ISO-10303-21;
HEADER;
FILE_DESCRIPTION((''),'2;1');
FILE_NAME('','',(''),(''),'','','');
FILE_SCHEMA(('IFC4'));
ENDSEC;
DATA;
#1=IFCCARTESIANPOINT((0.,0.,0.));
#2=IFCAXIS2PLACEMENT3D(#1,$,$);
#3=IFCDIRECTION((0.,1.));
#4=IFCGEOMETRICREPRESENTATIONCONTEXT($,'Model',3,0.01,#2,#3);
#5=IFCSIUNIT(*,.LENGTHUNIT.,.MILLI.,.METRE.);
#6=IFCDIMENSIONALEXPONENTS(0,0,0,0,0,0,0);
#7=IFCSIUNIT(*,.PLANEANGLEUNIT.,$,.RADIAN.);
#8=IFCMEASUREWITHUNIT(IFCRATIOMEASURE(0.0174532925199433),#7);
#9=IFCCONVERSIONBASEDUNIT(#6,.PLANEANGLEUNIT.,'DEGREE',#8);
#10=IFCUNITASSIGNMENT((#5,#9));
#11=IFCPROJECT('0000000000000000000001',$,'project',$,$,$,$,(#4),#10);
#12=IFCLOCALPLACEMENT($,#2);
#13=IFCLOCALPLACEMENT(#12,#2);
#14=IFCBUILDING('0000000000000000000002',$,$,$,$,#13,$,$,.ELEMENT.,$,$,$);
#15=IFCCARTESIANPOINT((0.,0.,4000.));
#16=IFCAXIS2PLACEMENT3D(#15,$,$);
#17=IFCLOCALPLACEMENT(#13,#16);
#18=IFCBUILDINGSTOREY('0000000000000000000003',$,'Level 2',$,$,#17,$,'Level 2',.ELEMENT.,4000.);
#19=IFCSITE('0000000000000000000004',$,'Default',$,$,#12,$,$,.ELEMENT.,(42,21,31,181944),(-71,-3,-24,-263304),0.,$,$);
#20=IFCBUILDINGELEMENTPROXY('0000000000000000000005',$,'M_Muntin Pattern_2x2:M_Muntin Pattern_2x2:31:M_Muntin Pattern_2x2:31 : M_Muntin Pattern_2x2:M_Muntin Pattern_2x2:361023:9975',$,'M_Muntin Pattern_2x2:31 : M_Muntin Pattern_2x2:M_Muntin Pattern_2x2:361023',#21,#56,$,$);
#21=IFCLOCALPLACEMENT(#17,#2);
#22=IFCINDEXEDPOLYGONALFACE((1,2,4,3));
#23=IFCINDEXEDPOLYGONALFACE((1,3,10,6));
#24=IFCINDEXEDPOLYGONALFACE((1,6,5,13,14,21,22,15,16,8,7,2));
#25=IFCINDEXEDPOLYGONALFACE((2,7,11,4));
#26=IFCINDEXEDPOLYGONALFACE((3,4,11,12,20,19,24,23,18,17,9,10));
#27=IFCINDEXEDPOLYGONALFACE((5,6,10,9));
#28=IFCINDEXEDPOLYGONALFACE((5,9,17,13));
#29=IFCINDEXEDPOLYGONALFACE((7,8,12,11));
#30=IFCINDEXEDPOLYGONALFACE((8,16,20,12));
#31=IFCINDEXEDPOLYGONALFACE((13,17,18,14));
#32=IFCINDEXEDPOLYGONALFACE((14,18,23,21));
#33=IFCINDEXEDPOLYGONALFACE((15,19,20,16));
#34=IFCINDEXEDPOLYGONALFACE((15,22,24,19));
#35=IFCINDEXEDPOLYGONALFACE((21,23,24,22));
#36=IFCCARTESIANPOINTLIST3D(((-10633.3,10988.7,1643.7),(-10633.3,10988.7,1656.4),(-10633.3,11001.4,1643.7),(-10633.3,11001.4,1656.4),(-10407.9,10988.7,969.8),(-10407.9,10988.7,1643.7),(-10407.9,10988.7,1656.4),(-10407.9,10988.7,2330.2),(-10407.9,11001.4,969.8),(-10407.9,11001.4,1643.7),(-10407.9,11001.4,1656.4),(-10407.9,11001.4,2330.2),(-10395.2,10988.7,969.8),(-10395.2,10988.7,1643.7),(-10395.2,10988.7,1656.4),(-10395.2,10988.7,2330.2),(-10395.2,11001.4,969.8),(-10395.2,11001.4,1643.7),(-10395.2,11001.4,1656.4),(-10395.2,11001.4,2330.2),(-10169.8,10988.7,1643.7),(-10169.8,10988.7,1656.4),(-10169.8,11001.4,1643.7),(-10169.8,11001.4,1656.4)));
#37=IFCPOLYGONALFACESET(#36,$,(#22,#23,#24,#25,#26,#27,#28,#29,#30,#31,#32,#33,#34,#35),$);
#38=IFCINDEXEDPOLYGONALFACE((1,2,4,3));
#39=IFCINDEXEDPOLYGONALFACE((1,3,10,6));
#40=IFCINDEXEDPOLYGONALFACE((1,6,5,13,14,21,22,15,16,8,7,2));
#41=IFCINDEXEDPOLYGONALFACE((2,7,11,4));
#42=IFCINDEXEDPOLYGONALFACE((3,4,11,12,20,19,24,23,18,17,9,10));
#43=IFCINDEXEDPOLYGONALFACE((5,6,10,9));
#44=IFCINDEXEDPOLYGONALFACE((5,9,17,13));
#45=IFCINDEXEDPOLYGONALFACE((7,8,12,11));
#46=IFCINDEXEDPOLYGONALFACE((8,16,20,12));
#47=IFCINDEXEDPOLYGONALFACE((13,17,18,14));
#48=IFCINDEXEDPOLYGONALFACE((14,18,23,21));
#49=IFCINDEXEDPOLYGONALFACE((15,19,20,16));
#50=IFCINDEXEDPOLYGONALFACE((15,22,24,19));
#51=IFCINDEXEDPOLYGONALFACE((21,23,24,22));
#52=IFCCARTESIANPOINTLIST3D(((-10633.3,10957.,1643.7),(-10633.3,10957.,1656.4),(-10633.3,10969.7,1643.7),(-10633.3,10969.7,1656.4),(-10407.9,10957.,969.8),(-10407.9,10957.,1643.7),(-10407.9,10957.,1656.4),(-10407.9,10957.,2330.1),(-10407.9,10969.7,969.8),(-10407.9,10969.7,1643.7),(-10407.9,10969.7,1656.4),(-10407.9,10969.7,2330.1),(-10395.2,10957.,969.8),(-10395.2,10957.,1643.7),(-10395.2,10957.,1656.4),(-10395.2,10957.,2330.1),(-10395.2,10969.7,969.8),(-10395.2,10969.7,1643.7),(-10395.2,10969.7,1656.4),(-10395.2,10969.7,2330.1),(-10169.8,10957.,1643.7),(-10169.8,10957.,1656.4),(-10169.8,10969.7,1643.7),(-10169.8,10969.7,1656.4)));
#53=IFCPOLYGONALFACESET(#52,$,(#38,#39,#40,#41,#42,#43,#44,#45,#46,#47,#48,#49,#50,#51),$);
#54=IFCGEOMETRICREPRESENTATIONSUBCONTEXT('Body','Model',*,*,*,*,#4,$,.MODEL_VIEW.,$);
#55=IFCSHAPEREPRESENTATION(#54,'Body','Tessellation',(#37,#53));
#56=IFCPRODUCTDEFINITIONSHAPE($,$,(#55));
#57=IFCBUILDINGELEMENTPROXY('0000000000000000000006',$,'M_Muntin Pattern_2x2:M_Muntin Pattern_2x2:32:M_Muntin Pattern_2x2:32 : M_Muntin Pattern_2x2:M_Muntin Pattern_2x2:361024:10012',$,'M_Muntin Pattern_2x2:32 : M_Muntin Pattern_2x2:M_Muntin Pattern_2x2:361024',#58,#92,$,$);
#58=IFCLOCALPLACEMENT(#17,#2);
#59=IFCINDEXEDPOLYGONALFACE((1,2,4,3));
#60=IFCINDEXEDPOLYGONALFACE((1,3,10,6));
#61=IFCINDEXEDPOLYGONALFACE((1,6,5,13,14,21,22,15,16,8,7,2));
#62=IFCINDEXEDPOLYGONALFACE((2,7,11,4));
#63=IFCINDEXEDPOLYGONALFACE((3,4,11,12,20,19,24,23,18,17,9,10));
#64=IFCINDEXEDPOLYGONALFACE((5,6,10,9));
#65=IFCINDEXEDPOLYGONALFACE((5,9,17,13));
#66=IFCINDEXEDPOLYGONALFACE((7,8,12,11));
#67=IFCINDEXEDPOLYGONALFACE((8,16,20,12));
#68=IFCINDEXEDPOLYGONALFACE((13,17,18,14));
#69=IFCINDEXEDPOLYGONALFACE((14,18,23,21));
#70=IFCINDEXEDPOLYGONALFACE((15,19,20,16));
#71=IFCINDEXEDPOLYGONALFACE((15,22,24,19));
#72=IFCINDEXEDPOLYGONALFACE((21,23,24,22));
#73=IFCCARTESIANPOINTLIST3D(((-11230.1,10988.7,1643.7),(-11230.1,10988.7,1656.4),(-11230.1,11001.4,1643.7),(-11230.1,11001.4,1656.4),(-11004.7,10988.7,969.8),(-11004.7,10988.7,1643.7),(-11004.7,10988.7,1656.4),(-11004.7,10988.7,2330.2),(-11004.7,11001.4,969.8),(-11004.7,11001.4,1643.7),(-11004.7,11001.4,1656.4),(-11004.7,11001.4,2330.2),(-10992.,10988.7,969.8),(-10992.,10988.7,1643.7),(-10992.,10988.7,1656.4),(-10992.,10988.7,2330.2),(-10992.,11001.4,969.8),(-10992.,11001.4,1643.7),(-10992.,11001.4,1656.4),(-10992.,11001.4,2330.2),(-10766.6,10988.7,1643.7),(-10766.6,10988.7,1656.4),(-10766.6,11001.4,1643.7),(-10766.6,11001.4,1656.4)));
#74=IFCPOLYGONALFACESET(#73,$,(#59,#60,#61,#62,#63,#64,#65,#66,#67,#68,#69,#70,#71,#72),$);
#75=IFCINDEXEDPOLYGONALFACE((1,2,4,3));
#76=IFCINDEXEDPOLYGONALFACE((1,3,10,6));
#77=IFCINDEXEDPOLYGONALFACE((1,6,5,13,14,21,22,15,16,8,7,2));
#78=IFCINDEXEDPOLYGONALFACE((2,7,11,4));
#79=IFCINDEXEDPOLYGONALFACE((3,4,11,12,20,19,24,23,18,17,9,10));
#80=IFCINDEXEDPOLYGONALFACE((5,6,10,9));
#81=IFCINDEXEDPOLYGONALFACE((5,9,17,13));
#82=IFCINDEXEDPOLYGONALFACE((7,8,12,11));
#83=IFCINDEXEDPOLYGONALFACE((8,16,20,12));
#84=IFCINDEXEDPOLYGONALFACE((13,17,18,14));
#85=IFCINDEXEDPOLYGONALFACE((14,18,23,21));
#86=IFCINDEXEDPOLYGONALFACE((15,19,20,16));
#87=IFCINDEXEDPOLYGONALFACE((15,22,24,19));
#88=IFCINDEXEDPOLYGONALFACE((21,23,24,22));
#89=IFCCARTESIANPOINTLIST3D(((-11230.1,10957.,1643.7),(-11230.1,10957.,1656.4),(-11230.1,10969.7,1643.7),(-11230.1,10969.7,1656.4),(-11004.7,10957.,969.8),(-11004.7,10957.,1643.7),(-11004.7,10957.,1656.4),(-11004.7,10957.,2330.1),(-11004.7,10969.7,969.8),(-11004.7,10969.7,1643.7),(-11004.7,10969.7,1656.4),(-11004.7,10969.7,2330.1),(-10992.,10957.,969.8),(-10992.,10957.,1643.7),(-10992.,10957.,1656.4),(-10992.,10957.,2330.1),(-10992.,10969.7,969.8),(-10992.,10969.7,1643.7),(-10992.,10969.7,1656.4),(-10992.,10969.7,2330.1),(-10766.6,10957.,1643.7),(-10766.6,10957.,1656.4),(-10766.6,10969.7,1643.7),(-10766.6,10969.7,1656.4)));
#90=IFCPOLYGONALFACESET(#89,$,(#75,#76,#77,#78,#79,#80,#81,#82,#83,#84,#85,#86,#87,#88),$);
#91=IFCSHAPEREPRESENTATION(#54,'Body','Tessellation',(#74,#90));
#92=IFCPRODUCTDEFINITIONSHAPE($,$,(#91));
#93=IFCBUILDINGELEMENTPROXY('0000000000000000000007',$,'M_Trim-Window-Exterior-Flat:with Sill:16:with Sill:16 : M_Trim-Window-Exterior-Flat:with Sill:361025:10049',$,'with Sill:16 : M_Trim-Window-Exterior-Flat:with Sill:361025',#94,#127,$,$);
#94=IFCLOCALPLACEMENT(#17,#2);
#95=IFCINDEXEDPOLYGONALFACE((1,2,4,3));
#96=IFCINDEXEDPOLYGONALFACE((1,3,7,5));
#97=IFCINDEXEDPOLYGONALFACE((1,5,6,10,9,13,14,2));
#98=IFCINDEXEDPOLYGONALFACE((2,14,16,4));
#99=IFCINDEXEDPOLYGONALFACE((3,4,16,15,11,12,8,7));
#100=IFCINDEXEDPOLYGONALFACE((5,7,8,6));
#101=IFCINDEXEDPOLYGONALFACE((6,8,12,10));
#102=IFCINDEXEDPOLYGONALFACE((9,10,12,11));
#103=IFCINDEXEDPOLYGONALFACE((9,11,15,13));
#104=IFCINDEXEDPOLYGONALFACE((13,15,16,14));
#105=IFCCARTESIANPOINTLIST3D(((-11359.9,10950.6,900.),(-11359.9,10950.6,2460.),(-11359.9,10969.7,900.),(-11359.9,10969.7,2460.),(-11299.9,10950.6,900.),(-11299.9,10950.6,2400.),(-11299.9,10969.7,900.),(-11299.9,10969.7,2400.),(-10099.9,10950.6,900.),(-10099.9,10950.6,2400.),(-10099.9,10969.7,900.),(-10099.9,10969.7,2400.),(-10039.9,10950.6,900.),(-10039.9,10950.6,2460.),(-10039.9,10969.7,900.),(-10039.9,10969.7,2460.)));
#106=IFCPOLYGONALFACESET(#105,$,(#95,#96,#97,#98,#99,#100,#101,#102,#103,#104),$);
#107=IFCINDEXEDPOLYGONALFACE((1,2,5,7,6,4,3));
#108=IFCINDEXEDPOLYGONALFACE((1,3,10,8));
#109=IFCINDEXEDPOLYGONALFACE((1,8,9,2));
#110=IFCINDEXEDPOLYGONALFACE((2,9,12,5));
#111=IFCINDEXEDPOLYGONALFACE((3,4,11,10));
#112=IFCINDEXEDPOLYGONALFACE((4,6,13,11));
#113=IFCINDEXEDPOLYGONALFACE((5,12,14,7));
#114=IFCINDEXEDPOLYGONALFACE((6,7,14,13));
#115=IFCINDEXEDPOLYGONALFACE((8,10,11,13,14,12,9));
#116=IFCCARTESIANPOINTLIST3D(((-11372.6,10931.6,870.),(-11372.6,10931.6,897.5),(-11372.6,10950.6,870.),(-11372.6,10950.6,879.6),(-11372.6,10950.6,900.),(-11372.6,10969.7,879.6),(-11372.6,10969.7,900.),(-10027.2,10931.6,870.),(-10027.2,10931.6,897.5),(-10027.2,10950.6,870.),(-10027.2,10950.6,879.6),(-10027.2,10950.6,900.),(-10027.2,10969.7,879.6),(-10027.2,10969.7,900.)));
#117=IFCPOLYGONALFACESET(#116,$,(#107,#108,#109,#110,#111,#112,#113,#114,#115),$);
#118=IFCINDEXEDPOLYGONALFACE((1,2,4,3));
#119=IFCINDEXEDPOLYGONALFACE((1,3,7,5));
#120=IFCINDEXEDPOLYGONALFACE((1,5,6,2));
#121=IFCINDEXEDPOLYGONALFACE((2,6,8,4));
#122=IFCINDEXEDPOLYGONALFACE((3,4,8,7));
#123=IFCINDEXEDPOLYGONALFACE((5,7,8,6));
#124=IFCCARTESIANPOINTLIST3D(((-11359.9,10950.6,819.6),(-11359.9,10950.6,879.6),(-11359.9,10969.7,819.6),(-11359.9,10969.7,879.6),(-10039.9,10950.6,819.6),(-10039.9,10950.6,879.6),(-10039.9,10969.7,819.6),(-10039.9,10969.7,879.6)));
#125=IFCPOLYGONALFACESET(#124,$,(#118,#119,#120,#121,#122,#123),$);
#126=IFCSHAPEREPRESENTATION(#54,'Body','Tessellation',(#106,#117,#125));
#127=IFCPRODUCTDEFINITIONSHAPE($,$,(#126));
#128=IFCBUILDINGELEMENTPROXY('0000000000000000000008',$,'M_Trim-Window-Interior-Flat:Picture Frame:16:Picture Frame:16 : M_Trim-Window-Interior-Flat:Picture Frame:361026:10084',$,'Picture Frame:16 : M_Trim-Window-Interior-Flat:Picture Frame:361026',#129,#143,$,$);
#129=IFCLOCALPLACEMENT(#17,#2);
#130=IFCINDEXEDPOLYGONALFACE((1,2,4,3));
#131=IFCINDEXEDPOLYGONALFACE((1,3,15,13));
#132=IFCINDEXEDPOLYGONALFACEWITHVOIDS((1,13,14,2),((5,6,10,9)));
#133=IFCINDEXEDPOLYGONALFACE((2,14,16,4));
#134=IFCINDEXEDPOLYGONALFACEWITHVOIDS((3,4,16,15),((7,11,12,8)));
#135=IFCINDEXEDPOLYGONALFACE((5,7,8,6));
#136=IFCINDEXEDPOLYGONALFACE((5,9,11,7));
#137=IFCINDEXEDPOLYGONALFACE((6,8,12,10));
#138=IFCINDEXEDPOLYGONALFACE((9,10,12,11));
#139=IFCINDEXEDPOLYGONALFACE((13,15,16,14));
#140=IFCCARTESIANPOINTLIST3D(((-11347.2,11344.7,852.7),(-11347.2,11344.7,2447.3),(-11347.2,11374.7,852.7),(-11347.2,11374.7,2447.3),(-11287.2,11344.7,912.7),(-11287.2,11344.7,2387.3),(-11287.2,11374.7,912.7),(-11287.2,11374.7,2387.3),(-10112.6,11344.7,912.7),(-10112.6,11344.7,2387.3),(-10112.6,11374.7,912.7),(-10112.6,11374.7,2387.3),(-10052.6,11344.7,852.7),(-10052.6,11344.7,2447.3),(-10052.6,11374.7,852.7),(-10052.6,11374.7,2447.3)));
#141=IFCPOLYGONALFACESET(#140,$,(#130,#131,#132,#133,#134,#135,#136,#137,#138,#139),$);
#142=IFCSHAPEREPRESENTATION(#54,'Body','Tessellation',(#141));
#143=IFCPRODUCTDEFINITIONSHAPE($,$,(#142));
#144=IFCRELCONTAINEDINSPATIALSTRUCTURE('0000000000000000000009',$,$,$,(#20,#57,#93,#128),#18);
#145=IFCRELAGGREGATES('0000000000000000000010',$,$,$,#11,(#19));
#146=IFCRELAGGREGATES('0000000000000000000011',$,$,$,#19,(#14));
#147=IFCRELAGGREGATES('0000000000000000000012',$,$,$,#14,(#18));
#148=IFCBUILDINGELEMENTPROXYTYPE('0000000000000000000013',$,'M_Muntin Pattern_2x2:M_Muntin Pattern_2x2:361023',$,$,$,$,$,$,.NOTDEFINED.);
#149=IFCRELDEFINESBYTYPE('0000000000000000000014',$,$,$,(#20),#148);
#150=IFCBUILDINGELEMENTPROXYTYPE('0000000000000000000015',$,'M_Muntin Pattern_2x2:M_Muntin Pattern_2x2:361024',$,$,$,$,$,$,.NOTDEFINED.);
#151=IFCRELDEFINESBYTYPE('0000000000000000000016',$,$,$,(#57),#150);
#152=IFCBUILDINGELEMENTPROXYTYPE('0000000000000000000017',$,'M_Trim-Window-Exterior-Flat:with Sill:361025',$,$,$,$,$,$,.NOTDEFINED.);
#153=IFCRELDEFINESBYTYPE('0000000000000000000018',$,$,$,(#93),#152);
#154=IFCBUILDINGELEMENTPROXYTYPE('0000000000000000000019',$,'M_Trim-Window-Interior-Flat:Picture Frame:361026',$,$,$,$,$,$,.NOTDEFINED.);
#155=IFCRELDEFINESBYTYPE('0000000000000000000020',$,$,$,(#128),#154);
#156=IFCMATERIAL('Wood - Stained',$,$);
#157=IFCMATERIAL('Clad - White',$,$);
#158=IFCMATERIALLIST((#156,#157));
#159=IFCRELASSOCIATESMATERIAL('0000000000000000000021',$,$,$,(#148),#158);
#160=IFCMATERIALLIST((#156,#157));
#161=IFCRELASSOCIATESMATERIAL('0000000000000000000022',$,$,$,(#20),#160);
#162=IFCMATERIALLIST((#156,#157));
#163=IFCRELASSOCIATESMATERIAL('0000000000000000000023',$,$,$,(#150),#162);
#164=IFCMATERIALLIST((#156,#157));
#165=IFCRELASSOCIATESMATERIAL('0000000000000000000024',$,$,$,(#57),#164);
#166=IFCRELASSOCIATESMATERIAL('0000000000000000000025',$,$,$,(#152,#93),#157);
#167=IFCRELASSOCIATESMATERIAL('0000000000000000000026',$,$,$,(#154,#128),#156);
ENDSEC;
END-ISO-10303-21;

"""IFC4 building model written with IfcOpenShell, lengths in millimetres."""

from ifc_helpers import new_model, entity, si_unit, converted_unit, direction, frame, frame_2d, origin, place, context, subcontext, project, spatial, polyline, rectangle, outline, extrude, source, transform, mapped, material, material_list, type_object, type_shapes, element, save


model = new_model("IFC4")

# Units and contexts
model_context = context("Model", 3, precision=0.01, world=origin(), true_north=direction((0.0, 1.0)))
body_context = subcontext(model_context, "Body", "Model", "MODEL_VIEW")
ifc_project = project(units=[si_unit("LENGTHUNIT", "METRE", prefix="MILLI"), converted_unit("PLANEANGLEUNIT", "DEGREE", entity("IfcRatioMeasure", 0.0174532925199433), si_unit("PLANEANGLEUNIT", "RADIAN"), dimensions=[0, 0, 0, 0, 0, 0, 0])], contexts=[model_context])

# Site, building, storey
site_placement = place(None, origin())
site = spatial("IfcSite", under=ifc_project, at=site_placement, Name="Default", CompositionType="ELEMENT", RefLatitude=(42, 21, 31, 181944), RefLongitude=(-71, -3, -24, -263304), RefElevation=0.0)
building_placement = place(site_placement, origin())
building = spatial("IfcBuilding", under=site, at=building_placement, CompositionType="ELEMENT")
storey_placement = place(building_placement, frame((0.0, 0.0, 4000.0)))
storey = spatial("IfcBuildingStorey", under=building, at=storey_placement, Name="Level 2", LongName="Level 2", CompositionType="ELEMENT", Elevation=4000.0)

# Building element proxies
ifc_material_1 = material(Name="Wood - Stained")
ifc_material_2 = material(Name="Clad - White")
ifc_material_list_1 = material_list([ifc_material_1, ifc_material_2])
ifc_material_list_2 = material_list([ifc_material_1, ifc_material_2])
building_element_proxy_type_1 = type_object("IfcBuildingElementProxyType", Name="M_Muntin Pattern_2x2:M_Muntin Pattern_2x2:361023", PredefinedType="NOTDEFINED", material=ifc_material_list_2)
shared_shape_1 = source(origin(), body_context, "Body", "SweptSolid", [
    extrude(outline(polyline([(-680.2, 6.4), (-680.2, -6.3), (-6.4, -6.3), (-6.4, -231.7), (6.3, -231.7), (6.3, -6.3), (680.2, -6.3), (680.2, 6.4), (6.3, 6.4), (6.3, 231.7), (-6.4, 231.7), (-6.4, 6.4), (-680.2, 6.4)])), frame((-10401.5, 10988.7, 5650.0), z_axis=(0.0, -1.0, 0.0), x_axis=(0.0, 0.0, -1.0)), (0.0, 0.0, -1.0), 12.7),
    extrude(outline(polyline([(-680.1, 6.4), (-680.1, -6.3), (-6.4, -6.3), (-6.4, -231.7), (6.3, -231.7), (6.3, -6.3), (680.2, -6.3), (680.2, 6.4), (6.3, 6.4), (6.3, 231.7), (-6.4, 231.7), (-6.4, 6.4), (-680.1, 6.4)])), frame((-10401.5, 10957.0, 5650.0), z_axis=(0.0, -1.0, 0.0), x_axis=(0.0, 0.0, -1.0)), (0.0, 0.0, -1.0), 12.7),
])
type_shapes(building_element_proxy_type_1, [shared_shape_1])
proxy_1_placement = place(storey_placement, frame((0.0, 0.0, -4000.0)))
element("IfcBuildingElementProxy", 1, at=proxy_1_placement, inside=storey, type_object=building_element_proxy_type_1, material=ifc_material_list_1, Name="M_Muntin Pattern_2x2:M_Muntin Pattern_2x2:31:M_Muntin Pattern_2x2:31 : M_Muntin Pattern_2x2:M_Muntin Pattern_2x2:361023:9975", ObjectType="M_Muntin Pattern_2x2:31 : M_Muntin Pattern_2x2:M_Muntin Pattern_2x2:361023", context=body_context, shape_type="MappedRepresentation", body=[
    mapped(shared_shape_1, transform((0.0, 0.0, 0.0), scale=1.0)),
])
ifc_material_list_3 = material_list([ifc_material_1, ifc_material_2])
ifc_material_list_4 = material_list([ifc_material_1, ifc_material_2])
building_element_proxy_type_2 = type_object("IfcBuildingElementProxyType", Name="M_Muntin Pattern_2x2:M_Muntin Pattern_2x2:361024", PredefinedType="NOTDEFINED", material=ifc_material_list_4)
shared_shape_2 = source(origin(), body_context, "Body", "SweptSolid", [
    extrude(outline(polyline([(-6.4, -680.1), (6.3, -680.1), (6.3, -6.4), (231.7, -6.4), (231.7, 6.3), (6.3, 6.3), (6.3, 680.2), (-6.4, 680.2), (-6.4, 6.3), (-231.7, 6.3), (-231.7, -6.4), (-6.4, -6.4), (-6.4, -680.1)])), frame((-10998.4, 10988.7, 5650.0), z_axis=(0.0, 1.0, 0.0), x_axis=(1.0, 0.0, 0.0)), (0.0, 0.0, 1.0), 12.7),
    extrude(outline(polyline([(-6.4, -680.1), (6.3, -680.1), (6.3, -6.4), (231.7, -6.4), (231.7, 6.3), (6.3, 6.3), (6.3, 680.2), (-6.4, 680.2), (-6.4, 6.3), (-231.7, 6.3), (-231.7, -6.4), (-6.4, -6.4), (-6.4, -680.1)])), frame((-10998.4, 10957.0, 5650.0), z_axis=(0.0, 1.0, 0.0), x_axis=(1.0, 0.0, 0.0)), (0.0, 0.0, 1.0), 12.7),
])
type_shapes(building_element_proxy_type_2, [shared_shape_2])
proxy_2_placement = place(storey_placement, frame((0.0, 0.0, -4000.0)))
element("IfcBuildingElementProxy", 2, at=proxy_2_placement, inside=storey, type_object=building_element_proxy_type_2, material=ifc_material_list_3, Name="M_Muntin Pattern_2x2:M_Muntin Pattern_2x2:32:M_Muntin Pattern_2x2:32 : M_Muntin Pattern_2x2:M_Muntin Pattern_2x2:361024:10012", ObjectType="M_Muntin Pattern_2x2:32 : M_Muntin Pattern_2x2:M_Muntin Pattern_2x2:361024", context=body_context, shape_type="MappedRepresentation", body=[
    mapped(shared_shape_2, transform((0.0, 0.0, 0.0), scale=1.0)),
])
building_element_proxy_type_3 = type_object("IfcBuildingElementProxyType", Name="M_Trim-Window-Exterior-Flat:with Sill:361025", PredefinedType="NOTDEFINED", material=ifc_material_2)
shared_shape_3 = source(origin(), body_context, "Body", "SweptSolid", [
    extrude(outline(polyline([(-765.0, -660.0), (795.0, -660.0), (795.0, 660.0), (-765.0, 660.0), (-765.0, 600.0), (735.0, 600.0), (735.0, -600.0), (-765.0, -600.0), (-765.0, -660.0)])), frame((-10699.9, 10950.6, 5665.0), z_axis=(0.0, 1.0, 0.0), x_axis=(0.0, 0.0, 1.0)), (0.0, 0.0, 1.0), 19.1),
    extrude(outline(polyline([(-15.2, 0.0), (-15.2, -19.0), (12.3, -19.0), (14.8, 0.0), (14.8, 19.0), (-5.7, 19.0), (-5.7, 0.0), (-15.2, 0.0)])), frame((-11372.6, 10950.6, 4885.2), z_axis=(-1.0, 0.0, 0.0), x_axis=(0.0, 0.0, 1.0)), (0.0, 0.0, -1.0), 1345.4),
    extrude(rectangle(XDim=19.1, YDim=1320.0, at=frame_2d((0.0, 0.0), x_axis=(1.0, 0.0))), frame((-10699.9, 10960.1, 4819.6), z_axis=(0.0, 0.0, 1.0), x_axis=(0.0, 1.0, 0.0)), (0.0, 0.0, 1.0), 60.0),
])
type_shapes(building_element_proxy_type_3, [shared_shape_3])
proxy_3_placement = place(storey_placement, frame((0.0, 0.0, -4000.0)))
element("IfcBuildingElementProxy", 3, at=proxy_3_placement, inside=storey, type_object=building_element_proxy_type_3, material=ifc_material_2, Name="M_Trim-Window-Exterior-Flat:with Sill:16:with Sill:16 : M_Trim-Window-Exterior-Flat:with Sill:361025:10049", ObjectType="with Sill:16 : M_Trim-Window-Exterior-Flat:with Sill:361025", context=body_context, shape_type="MappedRepresentation", body=[
    mapped(shared_shape_3, transform((0.0, 0.0, 0.0), scale=1.0)),
])
building_element_proxy_type_4 = type_object("IfcBuildingElementProxyType", Name="M_Trim-Window-Interior-Flat:Picture Frame:361026", PredefinedType="NOTDEFINED", material=ifc_material_1)
shared_shape_4 = source(origin(), body_context, "Body", "SweptSolid", [
    extrude(outline(polyline([(-797.3, -647.3), (797.3, -647.3), (797.3, 647.3), (-797.3, 647.3), (-797.3, -647.3)]), holes=[polyline([(737.3, 587.3), (737.3, -587.3), (-737.3, -587.3), (-737.3, 587.3), (737.3, 587.3)])]), frame((-10699.9, 11344.7, 5650.0), z_axis=(0.0, 1.0, 0.0), x_axis=(0.0, 0.0, -1.0)), (0.0, 0.0, 1.0), 30.0),
])
type_shapes(building_element_proxy_type_4, [shared_shape_4])
proxy_4_placement = place(storey_placement, frame((0.0, 0.0, -4000.0)))
element("IfcBuildingElementProxy", 4, at=proxy_4_placement, inside=storey, type_object=building_element_proxy_type_4, material=ifc_material_1, Name="M_Trim-Window-Interior-Flat:Picture Frame:16:Picture Frame:16 : M_Trim-Window-Interior-Flat:Picture Frame:361026:10084", ObjectType="Picture Frame:16 : M_Trim-Window-Interior-Flat:Picture Frame:361026", context=body_context, shape_type="MappedRepresentation", body=[
    mapped(shared_shape_4, transform((0.0, 0.0, 0.0), scale=1.0)),
])

save(model, "model.ifc")
